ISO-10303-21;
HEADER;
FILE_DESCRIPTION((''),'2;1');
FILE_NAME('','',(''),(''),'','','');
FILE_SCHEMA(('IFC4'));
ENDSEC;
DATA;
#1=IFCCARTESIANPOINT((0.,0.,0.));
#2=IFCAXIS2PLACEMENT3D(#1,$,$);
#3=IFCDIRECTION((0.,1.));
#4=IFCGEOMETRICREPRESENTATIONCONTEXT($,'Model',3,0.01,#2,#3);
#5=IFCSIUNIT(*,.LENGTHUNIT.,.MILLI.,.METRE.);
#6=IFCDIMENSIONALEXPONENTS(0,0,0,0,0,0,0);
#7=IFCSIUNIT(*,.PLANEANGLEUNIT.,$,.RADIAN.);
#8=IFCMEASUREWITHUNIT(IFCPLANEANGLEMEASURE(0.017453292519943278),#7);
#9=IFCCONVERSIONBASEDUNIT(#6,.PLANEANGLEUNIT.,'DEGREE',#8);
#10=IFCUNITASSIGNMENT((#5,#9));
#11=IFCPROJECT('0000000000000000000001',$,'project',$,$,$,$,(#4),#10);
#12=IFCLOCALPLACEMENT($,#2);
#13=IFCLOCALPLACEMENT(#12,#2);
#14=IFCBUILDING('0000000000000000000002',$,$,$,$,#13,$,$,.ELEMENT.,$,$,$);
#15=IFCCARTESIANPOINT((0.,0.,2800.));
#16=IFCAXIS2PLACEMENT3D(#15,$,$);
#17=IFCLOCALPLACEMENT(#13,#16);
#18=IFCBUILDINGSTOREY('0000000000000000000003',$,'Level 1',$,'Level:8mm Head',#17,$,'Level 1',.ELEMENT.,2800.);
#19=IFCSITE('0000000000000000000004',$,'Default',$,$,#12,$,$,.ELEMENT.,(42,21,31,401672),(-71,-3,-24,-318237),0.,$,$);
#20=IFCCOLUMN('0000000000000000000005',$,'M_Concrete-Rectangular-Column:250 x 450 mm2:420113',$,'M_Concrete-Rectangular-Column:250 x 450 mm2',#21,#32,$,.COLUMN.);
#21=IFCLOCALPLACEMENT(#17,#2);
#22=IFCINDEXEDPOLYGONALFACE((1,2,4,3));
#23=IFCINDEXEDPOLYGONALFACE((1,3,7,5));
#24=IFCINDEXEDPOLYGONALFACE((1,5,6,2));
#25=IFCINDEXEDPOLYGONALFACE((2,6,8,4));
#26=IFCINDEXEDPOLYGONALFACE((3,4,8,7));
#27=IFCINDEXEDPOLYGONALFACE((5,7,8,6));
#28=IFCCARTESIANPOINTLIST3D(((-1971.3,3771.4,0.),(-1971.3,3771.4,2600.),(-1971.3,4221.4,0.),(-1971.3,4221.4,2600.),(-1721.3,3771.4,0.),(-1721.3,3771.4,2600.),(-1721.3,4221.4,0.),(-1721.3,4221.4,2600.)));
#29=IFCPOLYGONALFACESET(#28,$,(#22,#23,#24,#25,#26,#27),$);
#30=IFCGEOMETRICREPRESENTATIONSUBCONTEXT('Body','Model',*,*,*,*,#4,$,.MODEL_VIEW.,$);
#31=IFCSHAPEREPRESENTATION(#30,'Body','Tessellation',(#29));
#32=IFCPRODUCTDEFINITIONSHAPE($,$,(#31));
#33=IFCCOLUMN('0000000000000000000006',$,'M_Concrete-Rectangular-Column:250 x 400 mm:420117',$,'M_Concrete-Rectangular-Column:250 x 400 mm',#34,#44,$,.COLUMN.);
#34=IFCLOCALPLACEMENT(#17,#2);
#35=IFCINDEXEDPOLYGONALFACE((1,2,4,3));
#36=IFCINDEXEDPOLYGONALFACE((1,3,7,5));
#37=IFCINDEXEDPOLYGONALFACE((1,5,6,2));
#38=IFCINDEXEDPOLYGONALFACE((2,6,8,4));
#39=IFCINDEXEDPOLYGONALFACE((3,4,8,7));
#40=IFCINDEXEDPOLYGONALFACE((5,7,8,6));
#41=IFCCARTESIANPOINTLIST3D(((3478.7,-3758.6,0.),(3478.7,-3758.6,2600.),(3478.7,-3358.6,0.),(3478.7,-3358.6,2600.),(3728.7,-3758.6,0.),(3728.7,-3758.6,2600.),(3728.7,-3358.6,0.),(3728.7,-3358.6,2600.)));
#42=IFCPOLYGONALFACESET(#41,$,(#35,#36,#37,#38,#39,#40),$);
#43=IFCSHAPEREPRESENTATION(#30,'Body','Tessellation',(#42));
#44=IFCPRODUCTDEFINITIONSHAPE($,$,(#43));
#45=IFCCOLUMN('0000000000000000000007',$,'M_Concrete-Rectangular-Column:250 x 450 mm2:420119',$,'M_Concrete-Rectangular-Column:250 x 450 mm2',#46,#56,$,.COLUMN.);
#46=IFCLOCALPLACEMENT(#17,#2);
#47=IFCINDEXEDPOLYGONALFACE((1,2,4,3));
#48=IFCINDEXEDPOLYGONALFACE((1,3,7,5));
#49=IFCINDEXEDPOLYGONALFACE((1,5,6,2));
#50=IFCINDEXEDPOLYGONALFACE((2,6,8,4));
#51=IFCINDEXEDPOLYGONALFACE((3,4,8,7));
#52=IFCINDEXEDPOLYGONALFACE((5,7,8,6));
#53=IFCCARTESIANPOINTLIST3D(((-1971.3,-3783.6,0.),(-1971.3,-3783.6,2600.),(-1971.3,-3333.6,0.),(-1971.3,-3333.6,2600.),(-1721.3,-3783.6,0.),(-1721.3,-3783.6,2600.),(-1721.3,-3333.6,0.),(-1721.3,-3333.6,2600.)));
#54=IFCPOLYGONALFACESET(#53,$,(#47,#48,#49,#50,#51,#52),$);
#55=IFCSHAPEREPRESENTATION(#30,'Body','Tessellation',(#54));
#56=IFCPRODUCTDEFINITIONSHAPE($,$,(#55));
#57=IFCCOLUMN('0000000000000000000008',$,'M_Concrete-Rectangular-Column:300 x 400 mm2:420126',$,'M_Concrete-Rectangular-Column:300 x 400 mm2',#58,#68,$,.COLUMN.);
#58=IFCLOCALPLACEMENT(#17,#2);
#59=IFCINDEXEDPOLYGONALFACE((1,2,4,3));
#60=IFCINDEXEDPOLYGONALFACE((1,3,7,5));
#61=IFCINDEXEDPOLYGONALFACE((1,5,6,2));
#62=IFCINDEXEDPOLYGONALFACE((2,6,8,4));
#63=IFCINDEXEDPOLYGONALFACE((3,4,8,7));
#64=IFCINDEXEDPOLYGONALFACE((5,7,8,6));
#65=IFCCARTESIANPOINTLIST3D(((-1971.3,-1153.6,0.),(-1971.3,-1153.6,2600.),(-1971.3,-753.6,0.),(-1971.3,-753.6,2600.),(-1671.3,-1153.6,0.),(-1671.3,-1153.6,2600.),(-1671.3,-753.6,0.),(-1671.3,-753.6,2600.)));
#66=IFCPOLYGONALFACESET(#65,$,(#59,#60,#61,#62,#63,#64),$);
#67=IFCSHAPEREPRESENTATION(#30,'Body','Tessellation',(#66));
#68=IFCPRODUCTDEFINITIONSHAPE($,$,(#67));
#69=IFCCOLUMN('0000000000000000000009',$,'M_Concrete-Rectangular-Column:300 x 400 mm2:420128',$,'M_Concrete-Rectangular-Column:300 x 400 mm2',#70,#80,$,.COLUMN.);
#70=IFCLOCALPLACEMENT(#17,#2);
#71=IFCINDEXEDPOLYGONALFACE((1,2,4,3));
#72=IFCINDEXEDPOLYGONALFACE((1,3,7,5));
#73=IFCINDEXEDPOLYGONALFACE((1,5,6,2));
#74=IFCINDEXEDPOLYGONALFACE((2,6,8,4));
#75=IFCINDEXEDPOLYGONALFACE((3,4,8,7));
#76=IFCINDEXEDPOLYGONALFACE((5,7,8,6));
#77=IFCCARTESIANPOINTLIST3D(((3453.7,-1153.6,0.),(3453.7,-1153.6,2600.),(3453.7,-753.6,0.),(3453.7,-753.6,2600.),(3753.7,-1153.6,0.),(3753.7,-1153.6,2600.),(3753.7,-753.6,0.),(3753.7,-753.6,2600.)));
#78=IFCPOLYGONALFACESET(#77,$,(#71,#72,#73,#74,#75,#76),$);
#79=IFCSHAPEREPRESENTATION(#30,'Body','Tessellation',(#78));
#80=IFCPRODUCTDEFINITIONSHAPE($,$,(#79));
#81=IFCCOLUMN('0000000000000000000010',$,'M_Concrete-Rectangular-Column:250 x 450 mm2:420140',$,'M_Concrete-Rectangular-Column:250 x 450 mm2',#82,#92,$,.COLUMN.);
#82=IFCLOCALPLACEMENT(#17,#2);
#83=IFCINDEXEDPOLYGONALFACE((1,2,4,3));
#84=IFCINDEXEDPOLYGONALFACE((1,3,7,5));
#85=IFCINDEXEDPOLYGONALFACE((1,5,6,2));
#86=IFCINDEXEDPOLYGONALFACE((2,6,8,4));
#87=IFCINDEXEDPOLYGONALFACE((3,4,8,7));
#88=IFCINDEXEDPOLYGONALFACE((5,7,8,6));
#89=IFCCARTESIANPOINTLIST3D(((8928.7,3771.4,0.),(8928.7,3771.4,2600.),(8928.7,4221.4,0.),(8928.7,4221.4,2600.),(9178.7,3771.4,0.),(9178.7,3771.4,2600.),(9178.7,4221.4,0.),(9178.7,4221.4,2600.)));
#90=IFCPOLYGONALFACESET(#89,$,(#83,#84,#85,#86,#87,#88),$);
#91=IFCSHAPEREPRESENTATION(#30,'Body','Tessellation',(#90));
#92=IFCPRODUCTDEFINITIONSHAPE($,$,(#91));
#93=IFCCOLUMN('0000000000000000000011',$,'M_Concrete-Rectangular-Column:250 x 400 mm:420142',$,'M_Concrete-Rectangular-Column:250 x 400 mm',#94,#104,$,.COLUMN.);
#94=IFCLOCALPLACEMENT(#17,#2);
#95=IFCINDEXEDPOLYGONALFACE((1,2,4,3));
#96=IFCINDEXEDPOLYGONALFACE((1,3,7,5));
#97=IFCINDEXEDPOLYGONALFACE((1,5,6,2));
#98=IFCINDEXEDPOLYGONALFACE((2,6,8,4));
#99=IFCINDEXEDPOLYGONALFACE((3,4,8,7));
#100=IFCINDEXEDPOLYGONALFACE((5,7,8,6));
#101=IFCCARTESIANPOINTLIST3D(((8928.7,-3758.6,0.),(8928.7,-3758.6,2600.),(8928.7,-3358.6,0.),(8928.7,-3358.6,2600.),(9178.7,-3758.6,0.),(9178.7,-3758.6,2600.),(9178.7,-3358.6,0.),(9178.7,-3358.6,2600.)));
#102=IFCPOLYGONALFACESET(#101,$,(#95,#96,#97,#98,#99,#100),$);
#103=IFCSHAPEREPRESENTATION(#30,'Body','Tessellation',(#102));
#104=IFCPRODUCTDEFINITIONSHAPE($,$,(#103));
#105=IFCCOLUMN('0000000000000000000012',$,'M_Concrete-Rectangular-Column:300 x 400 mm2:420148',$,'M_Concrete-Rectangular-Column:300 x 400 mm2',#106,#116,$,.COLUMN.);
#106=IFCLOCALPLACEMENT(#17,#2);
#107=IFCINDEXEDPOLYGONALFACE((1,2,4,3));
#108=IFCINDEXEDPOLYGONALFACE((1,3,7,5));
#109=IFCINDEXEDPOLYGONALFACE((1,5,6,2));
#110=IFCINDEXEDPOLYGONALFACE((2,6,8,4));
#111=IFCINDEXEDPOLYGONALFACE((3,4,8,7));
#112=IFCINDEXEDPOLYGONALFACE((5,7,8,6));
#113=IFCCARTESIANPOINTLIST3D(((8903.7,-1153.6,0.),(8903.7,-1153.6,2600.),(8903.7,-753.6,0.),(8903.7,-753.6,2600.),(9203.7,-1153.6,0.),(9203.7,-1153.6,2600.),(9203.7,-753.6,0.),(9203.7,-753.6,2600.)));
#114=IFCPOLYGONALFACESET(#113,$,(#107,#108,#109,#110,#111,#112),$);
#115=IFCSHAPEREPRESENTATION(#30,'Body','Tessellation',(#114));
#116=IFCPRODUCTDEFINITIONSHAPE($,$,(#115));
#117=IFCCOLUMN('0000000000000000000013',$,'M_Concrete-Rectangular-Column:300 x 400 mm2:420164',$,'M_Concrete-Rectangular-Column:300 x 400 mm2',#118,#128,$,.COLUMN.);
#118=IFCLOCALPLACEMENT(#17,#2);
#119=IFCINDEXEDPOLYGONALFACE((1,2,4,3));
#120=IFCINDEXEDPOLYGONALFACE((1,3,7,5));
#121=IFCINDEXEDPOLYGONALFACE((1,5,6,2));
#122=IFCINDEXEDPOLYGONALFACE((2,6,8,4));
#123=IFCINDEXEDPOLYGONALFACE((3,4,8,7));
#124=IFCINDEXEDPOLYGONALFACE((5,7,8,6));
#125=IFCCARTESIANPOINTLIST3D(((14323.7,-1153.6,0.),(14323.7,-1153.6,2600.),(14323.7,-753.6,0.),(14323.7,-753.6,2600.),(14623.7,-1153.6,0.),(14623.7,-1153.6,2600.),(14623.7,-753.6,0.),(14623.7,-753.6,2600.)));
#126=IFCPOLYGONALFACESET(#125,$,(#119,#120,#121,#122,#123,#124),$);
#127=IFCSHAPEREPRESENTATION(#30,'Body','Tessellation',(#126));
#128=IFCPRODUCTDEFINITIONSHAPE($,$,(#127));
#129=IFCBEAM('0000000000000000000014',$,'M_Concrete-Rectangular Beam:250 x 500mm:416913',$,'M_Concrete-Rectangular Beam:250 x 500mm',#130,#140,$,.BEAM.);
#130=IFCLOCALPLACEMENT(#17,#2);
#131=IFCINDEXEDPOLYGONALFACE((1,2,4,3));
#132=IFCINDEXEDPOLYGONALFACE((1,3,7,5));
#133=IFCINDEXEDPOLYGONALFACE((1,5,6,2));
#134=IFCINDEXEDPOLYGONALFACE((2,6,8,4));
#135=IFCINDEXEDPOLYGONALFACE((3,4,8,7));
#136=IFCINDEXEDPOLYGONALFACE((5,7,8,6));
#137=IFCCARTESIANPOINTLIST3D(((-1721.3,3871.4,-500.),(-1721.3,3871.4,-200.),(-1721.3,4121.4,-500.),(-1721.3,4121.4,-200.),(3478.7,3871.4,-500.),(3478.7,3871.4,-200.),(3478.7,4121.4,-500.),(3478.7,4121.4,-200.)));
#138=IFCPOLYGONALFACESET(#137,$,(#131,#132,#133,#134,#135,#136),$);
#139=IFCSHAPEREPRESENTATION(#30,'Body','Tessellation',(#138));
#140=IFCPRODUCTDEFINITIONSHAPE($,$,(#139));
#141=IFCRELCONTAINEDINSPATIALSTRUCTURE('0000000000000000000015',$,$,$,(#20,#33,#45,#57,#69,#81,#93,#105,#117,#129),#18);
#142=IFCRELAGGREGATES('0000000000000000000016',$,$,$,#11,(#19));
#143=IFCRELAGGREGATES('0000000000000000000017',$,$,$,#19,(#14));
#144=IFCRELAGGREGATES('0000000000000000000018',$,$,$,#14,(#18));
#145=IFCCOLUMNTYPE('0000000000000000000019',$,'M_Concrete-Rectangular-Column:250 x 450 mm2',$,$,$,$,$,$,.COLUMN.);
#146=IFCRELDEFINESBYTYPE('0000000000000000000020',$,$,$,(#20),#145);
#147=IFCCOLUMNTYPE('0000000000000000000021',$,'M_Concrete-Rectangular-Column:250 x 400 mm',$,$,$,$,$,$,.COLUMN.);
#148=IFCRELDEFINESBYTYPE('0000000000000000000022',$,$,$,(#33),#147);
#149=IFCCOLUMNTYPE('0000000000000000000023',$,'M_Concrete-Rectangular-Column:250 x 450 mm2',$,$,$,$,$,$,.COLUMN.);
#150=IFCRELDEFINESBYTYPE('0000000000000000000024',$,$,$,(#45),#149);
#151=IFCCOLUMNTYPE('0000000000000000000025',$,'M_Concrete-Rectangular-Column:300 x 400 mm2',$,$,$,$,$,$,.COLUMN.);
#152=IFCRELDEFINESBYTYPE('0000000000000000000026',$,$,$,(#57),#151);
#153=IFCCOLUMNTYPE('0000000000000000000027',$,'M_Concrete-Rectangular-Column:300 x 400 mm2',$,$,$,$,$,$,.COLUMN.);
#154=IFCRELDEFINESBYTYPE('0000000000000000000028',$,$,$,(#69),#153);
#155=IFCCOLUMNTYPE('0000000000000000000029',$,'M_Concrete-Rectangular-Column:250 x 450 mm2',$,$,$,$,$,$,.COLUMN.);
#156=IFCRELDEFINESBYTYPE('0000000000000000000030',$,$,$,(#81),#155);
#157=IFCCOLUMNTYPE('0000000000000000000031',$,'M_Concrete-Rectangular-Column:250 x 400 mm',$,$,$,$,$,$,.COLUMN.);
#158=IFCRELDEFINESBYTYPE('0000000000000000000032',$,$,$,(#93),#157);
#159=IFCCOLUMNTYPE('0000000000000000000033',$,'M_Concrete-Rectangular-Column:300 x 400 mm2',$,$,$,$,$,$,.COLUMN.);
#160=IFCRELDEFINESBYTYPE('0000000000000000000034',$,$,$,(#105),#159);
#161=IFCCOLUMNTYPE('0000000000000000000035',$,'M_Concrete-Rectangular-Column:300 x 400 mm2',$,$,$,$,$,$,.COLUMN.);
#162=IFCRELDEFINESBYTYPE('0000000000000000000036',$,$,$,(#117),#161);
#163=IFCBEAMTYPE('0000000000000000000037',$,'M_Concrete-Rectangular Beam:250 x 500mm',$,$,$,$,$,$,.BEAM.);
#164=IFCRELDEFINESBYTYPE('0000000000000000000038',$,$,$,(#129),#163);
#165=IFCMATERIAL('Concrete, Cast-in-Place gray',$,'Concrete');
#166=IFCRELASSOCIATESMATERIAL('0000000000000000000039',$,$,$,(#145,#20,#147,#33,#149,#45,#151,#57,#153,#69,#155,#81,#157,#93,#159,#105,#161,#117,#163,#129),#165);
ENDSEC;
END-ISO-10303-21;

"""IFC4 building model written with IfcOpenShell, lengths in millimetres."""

from ifc_helpers import new_model, entity, si_unit, converted_unit, direction, frame, origin, place, context, subcontext, project, spatial, indexed_curve, outline, extrude, source, transform, mapped, material, type_object, type_shapes, element, save


model = new_model("IFC4")

# Units and contexts
model_context = context("Model", 3, precision=0.01, world=origin(), true_north=direction((0.0, 1.0)))
body_context = subcontext(model_context, "Body", "Model", "MODEL_VIEW")
ifc_project = project(units=[si_unit("LENGTHUNIT", "METRE", prefix="MILLI"), converted_unit("PLANEANGLEUNIT", "DEGREE", entity("IfcPlaneAngleMeasure", 0.017453292519943278), si_unit("PLANEANGLEUNIT", "RADIAN"), dimensions=[0, 0, 0, 0, 0, 0, 0])], contexts=[model_context])

# Site, building, storey
site_placement = place(None, origin())
site = spatial("IfcSite", under=ifc_project, at=site_placement, Name="Default", CompositionType="ELEMENT", RefLatitude=(42, 21, 31, 401672), RefLongitude=(-71, -3, -24, -318237), RefElevation=0.0)
building_placement = place(site_placement, origin())
building = spatial("IfcBuilding", under=site, at=building_placement, CompositionType="ELEMENT")
storey_placement = place(building_placement, frame((0.0, 0.0, 2800.0)))
storey = spatial("IfcBuildingStorey", under=building, at=storey_placement, Name="Level 1", ObjectType="Level:8mm Head", LongName="Level 1", CompositionType="ELEMENT", Elevation=2800.0)

# Columns
ifc_material_1 = material(Name="Concrete, Cast-in-Place gray", Category="Concrete")
column_type_1 = type_object("IfcColumnType", Name="M_Concrete-Rectangular-Column:250 x 450 mm2", PredefinedType="COLUMN", material=ifc_material_1)
shared_shape_1 = source(origin(), body_context, "Body", "SweptSolid", [
    extrude(outline(indexed_curve([(-1300.0, -225.0), (1300.0, -225.0), (1300.0, 225.0), (-1300.0, 225.0), (-1300.0, -225.0)], self_intersect=False)), frame((-1971.3, 3996.4, 4100.0), z_axis=(1.0, 0.0, 0.0), x_axis=(0.0, 0.0, 1.0)), (0.0, 0.0, 1.0), 250.0),
])
type_shapes(column_type_1, [shared_shape_1])
column_1_placement = place(storey_placement, frame((0.0, 0.0, -2800.0)))
element("IfcColumn", 1, at=column_1_placement, inside=storey, type_object=column_type_1, material=ifc_material_1, Name="M_Concrete-Rectangular-Column:250 x 450 mm2:420113", ObjectType="M_Concrete-Rectangular-Column:250 x 450 mm2", PredefinedType="COLUMN", context=body_context, shape_type="MappedRepresentation", body=[
    mapped(shared_shape_1, transform((0.0, 0.0, 0.0), scale=1.0)),
])
column_type_2 = type_object("IfcColumnType", Name="M_Concrete-Rectangular-Column:250 x 400 mm", PredefinedType="COLUMN", material=ifc_material_1)
shared_shape_2 = source(origin(), body_context, "Body", "SweptSolid", [
    extrude(outline(indexed_curve([(-1300.0, -200.0), (1300.0, -200.0), (1300.0, 200.0), (-1300.0, 200.0), (-1300.0, -200.0)], self_intersect=False)), frame((3478.7, -3558.6, 4100.0), z_axis=(1.0, 0.0, 0.0), x_axis=(0.0, 0.0, 1.0)), (0.0, 0.0, 1.0), 250.0),
])
type_shapes(column_type_2, [shared_shape_2])
column_2_placement = place(storey_placement, frame((0.0, 0.0, -2800.0)))
element("IfcColumn", 2, at=column_2_placement, inside=storey, type_object=column_type_2, material=ifc_material_1, Name="M_Concrete-Rectangular-Column:250 x 400 mm:420117", ObjectType="M_Concrete-Rectangular-Column:250 x 400 mm", PredefinedType="COLUMN", context=body_context, shape_type="MappedRepresentation", body=[
    mapped(shared_shape_2, transform((0.0, 0.0, 0.0), scale=1.0)),
])
column_type_3 = type_object("IfcColumnType", Name="M_Concrete-Rectangular-Column:250 x 450 mm2", PredefinedType="COLUMN", material=ifc_material_1)
shared_shape_3 = source(origin(), body_context, "Body", "SweptSolid", [
    extrude(outline(indexed_curve([(-1300.0, -225.0), (1300.0, -225.0), (1300.0, 225.0), (-1300.0, 225.0), (-1300.0, -225.0)], self_intersect=False)), frame((-1971.3, -3558.6, 4100.0), z_axis=(1.0, 0.0, 0.0), x_axis=(0.0, 0.0, 1.0)), (0.0, 0.0, 1.0), 250.0),
])
type_shapes(column_type_3, [shared_shape_3])
column_3_placement = place(storey_placement, frame((0.0, 0.0, -2800.0)))
element("IfcColumn", 3, at=column_3_placement, inside=storey, type_object=column_type_3, material=ifc_material_1, Name="M_Concrete-Rectangular-Column:250 x 450 mm2:420119", ObjectType="M_Concrete-Rectangular-Column:250 x 450 mm2", PredefinedType="COLUMN", context=body_context, shape_type="MappedRepresentation", body=[
    mapped(shared_shape_3, transform((0.0, 0.0, 0.0), scale=1.0)),
])
column_type_4 = type_object("IfcColumnType", Name="M_Concrete-Rectangular-Column:300 x 400 mm2", PredefinedType="COLUMN", material=ifc_material_1)
shared_shape_4 = source(origin(), body_context, "Body", "SweptSolid", [
    extrude(outline(indexed_curve([(-1300.0, -200.0), (1300.0, -200.0), (1300.0, 200.0), (-1300.0, 200.0), (-1300.0, -200.0)], self_intersect=False)), frame((-1971.3, -953.6, 4100.0), z_axis=(1.0, 0.0, 0.0), x_axis=(0.0, 0.0, 1.0)), (0.0, 0.0, 1.0), 300.0),
])
type_shapes(column_type_4, [shared_shape_4])
column_4_placement = place(storey_placement, frame((0.0, 0.0, -2800.0)))
element("IfcColumn", 4, at=column_4_placement, inside=storey, type_object=column_type_4, material=ifc_material_1, Name="M_Concrete-Rectangular-Column:300 x 400 mm2:420126", ObjectType="M_Concrete-Rectangular-Column:300 x 400 mm2", PredefinedType="COLUMN", context=body_context, shape_type="MappedRepresentation", body=[
    mapped(shared_shape_4, transform((0.0, 0.0, 0.0), scale=1.0)),
])
column_type_5 = type_object("IfcColumnType", Name="M_Concrete-Rectangular-Column:300 x 400 mm2", PredefinedType="COLUMN", material=ifc_material_1)
shared_shape_5 = source(origin(), body_context, "Body", "SweptSolid", [
    extrude(outline(indexed_curve([(-1300.0, -200.0), (1300.0, -200.0), (1300.0, 200.0), (-1300.0, 200.0), (-1300.0, -200.0)], self_intersect=False)), frame((3453.7, -953.6, 4100.0), z_axis=(1.0, 0.0, 0.0), x_axis=(0.0, 0.0, 1.0)), (0.0, 0.0, 1.0), 300.0),
])
type_shapes(column_type_5, [shared_shape_5])
column_5_placement = place(storey_placement, frame((0.0, 0.0, -2800.0)))
element("IfcColumn", 5, at=column_5_placement, inside=storey, type_object=column_type_5, material=ifc_material_1, Name="M_Concrete-Rectangular-Column:300 x 400 mm2:420128", ObjectType="M_Concrete-Rectangular-Column:300 x 400 mm2", PredefinedType="COLUMN", context=body_context, shape_type="MappedRepresentation", body=[
    mapped(shared_shape_5, transform((0.0, 0.0, 0.0), scale=1.0)),
])
column_type_6 = type_object("IfcColumnType", Name="M_Concrete-Rectangular-Column:250 x 450 mm2", PredefinedType="COLUMN", material=ifc_material_1)
shared_shape_6 = source(origin(), body_context, "Body", "SweptSolid", [
    extrude(outline(indexed_curve([(-1300.0, -225.0), (1300.0, -225.0), (1300.0, 225.0), (-1300.0, 225.0), (-1300.0, -225.0)], self_intersect=False)), frame((8928.7, 3996.4, 4100.0), z_axis=(1.0, 0.0, 0.0), x_axis=(0.0, 0.0, 1.0)), (0.0, 0.0, 1.0), 250.0),
])
type_shapes(column_type_6, [shared_shape_6])
column_6_placement = place(storey_placement, frame((0.0, 0.0, -2800.0)))
element("IfcColumn", 6, at=column_6_placement, inside=storey, type_object=column_type_6, material=ifc_material_1, Name="M_Concrete-Rectangular-Column:250 x 450 mm2:420140", ObjectType="M_Concrete-Rectangular-Column:250 x 450 mm2", PredefinedType="COLUMN", context=body_context, shape_type="MappedRepresentation", body=[
    mapped(shared_shape_6, transform((0.0, 0.0, 0.0), scale=1.0)),
])
column_type_7 = type_object("IfcColumnType", Name="M_Concrete-Rectangular-Column:250 x 400 mm", PredefinedType="COLUMN", material=ifc_material_1)
shared_shape_7 = source(origin(), body_context, "Body", "SweptSolid", [
    extrude(outline(indexed_curve([(-1300.0, -200.0), (1300.0, -200.0), (1300.0, 200.0), (-1300.0, 200.0), (-1300.0, -200.0)], self_intersect=False)), frame((8928.7, -3558.6, 4100.0), z_axis=(1.0, 0.0, 0.0), x_axis=(0.0, 0.0, 1.0)), (0.0, 0.0, 1.0), 250.0),
])
type_shapes(column_type_7, [shared_shape_7])
column_7_placement = place(storey_placement, frame((0.0, 0.0, -2800.0)))
element("IfcColumn", 7, at=column_7_placement, inside=storey, type_object=column_type_7, material=ifc_material_1, Name="M_Concrete-Rectangular-Column:250 x 400 mm:420142", ObjectType="M_Concrete-Rectangular-Column:250 x 400 mm", PredefinedType="COLUMN", context=body_context, shape_type="MappedRepresentation", body=[
    mapped(shared_shape_7, transform((0.0, 0.0, 0.0), scale=1.0)),
])
column_type_8 = type_object("IfcColumnType", Name="M_Concrete-Rectangular-Column:300 x 400 mm2", PredefinedType="COLUMN", material=ifc_material_1)
shared_shape_8 = source(origin(), body_context, "Body", "SweptSolid", [
    extrude(outline(indexed_curve([(-1300.0, -200.0), (1300.0, -200.0), (1300.0, 200.0), (-1300.0, 200.0), (-1300.0, -200.0)], self_intersect=False)), frame((8903.7, -953.6, 4100.0), z_axis=(1.0, 0.0, 0.0), x_axis=(0.0, 0.0, 1.0)), (0.0, 0.0, 1.0), 300.0),
])
type_shapes(column_type_8, [shared_shape_8])
column_8_placement = place(storey_placement, frame((0.0, 0.0, -2800.0)))
element("IfcColumn", 8, at=column_8_placement, inside=storey, type_object=column_type_8, material=ifc_material_1, Name="M_Concrete-Rectangular-Column:300 x 400 mm2:420148", ObjectType="M_Concrete-Rectangular-Column:300 x 400 mm2", PredefinedType="COLUMN", context=body_context, shape_type="MappedRepresentation", body=[
    mapped(shared_shape_8, transform((0.0, 0.0, 0.0), scale=1.0)),
])
column_type_9 = type_object("IfcColumnType", Name="M_Concrete-Rectangular-Column:300 x 400 mm2", PredefinedType="COLUMN", material=ifc_material_1)
shared_shape_9 = source(origin(), body_context, "Body", "SweptSolid", [
    extrude(outline(indexed_curve([(-1300.0, -200.0), (1300.0, -200.0), (1300.0, 200.0), (-1300.0, 200.0), (-1300.0, -200.0)], self_intersect=False)), frame((14323.7, -953.6, 4100.0), z_axis=(1.0, 0.0, 0.0), x_axis=(0.0, 0.0, 1.0)), (0.0, 0.0, 1.0), 300.0),
])
type_shapes(column_type_9, [shared_shape_9])
column_9_placement = place(storey_placement, frame((0.0, 0.0, -2800.0)))
element("IfcColumn", 9, at=column_9_placement, inside=storey, type_object=column_type_9, material=ifc_material_1, Name="M_Concrete-Rectangular-Column:300 x 400 mm2:420164", ObjectType="M_Concrete-Rectangular-Column:300 x 400 mm2", PredefinedType="COLUMN", context=body_context, shape_type="MappedRepresentation", body=[
    mapped(shared_shape_9, transform((0.0, 0.0, 0.0), scale=1.0)),
])

# Beam
beam_type_1 = type_object("IfcBeamType", Name="M_Concrete-Rectangular Beam:250 x 500mm", PredefinedType="BEAM", material=ifc_material_1)
shared_shape_10 = source(origin(), body_context, "Body", "SweptSolid", [
    extrude(outline(indexed_curve([(-150.0, -125.0), (150.0, -125.0), (150.0, 125.0), (-150.0, 125.0), (-150.0, -125.0)], self_intersect=False)), frame((-1721.3, 3996.4, 2450.0), z_axis=(1.0, 0.0, 0.0), x_axis=(0.0, 0.0, -1.0)), (0.0, 0.0, 1.0), 5200.0),
])
type_shapes(beam_type_1, [shared_shape_10])
beam_1_placement = place(storey_placement, frame((0.0, 0.0, -2800.0)))
element("IfcBeam", 10, at=beam_1_placement, inside=storey, type_object=beam_type_1, material=ifc_material_1, Name="M_Concrete-Rectangular Beam:250 x 500mm:416913", ObjectType="M_Concrete-Rectangular Beam:250 x 500mm", PredefinedType="BEAM", context=body_context, shape_type="MappedRepresentation", body=[
    mapped(shared_shape_10, transform((0.0, 0.0, 0.0), scale=1.0)),
])

save(model, "model.ifc")
